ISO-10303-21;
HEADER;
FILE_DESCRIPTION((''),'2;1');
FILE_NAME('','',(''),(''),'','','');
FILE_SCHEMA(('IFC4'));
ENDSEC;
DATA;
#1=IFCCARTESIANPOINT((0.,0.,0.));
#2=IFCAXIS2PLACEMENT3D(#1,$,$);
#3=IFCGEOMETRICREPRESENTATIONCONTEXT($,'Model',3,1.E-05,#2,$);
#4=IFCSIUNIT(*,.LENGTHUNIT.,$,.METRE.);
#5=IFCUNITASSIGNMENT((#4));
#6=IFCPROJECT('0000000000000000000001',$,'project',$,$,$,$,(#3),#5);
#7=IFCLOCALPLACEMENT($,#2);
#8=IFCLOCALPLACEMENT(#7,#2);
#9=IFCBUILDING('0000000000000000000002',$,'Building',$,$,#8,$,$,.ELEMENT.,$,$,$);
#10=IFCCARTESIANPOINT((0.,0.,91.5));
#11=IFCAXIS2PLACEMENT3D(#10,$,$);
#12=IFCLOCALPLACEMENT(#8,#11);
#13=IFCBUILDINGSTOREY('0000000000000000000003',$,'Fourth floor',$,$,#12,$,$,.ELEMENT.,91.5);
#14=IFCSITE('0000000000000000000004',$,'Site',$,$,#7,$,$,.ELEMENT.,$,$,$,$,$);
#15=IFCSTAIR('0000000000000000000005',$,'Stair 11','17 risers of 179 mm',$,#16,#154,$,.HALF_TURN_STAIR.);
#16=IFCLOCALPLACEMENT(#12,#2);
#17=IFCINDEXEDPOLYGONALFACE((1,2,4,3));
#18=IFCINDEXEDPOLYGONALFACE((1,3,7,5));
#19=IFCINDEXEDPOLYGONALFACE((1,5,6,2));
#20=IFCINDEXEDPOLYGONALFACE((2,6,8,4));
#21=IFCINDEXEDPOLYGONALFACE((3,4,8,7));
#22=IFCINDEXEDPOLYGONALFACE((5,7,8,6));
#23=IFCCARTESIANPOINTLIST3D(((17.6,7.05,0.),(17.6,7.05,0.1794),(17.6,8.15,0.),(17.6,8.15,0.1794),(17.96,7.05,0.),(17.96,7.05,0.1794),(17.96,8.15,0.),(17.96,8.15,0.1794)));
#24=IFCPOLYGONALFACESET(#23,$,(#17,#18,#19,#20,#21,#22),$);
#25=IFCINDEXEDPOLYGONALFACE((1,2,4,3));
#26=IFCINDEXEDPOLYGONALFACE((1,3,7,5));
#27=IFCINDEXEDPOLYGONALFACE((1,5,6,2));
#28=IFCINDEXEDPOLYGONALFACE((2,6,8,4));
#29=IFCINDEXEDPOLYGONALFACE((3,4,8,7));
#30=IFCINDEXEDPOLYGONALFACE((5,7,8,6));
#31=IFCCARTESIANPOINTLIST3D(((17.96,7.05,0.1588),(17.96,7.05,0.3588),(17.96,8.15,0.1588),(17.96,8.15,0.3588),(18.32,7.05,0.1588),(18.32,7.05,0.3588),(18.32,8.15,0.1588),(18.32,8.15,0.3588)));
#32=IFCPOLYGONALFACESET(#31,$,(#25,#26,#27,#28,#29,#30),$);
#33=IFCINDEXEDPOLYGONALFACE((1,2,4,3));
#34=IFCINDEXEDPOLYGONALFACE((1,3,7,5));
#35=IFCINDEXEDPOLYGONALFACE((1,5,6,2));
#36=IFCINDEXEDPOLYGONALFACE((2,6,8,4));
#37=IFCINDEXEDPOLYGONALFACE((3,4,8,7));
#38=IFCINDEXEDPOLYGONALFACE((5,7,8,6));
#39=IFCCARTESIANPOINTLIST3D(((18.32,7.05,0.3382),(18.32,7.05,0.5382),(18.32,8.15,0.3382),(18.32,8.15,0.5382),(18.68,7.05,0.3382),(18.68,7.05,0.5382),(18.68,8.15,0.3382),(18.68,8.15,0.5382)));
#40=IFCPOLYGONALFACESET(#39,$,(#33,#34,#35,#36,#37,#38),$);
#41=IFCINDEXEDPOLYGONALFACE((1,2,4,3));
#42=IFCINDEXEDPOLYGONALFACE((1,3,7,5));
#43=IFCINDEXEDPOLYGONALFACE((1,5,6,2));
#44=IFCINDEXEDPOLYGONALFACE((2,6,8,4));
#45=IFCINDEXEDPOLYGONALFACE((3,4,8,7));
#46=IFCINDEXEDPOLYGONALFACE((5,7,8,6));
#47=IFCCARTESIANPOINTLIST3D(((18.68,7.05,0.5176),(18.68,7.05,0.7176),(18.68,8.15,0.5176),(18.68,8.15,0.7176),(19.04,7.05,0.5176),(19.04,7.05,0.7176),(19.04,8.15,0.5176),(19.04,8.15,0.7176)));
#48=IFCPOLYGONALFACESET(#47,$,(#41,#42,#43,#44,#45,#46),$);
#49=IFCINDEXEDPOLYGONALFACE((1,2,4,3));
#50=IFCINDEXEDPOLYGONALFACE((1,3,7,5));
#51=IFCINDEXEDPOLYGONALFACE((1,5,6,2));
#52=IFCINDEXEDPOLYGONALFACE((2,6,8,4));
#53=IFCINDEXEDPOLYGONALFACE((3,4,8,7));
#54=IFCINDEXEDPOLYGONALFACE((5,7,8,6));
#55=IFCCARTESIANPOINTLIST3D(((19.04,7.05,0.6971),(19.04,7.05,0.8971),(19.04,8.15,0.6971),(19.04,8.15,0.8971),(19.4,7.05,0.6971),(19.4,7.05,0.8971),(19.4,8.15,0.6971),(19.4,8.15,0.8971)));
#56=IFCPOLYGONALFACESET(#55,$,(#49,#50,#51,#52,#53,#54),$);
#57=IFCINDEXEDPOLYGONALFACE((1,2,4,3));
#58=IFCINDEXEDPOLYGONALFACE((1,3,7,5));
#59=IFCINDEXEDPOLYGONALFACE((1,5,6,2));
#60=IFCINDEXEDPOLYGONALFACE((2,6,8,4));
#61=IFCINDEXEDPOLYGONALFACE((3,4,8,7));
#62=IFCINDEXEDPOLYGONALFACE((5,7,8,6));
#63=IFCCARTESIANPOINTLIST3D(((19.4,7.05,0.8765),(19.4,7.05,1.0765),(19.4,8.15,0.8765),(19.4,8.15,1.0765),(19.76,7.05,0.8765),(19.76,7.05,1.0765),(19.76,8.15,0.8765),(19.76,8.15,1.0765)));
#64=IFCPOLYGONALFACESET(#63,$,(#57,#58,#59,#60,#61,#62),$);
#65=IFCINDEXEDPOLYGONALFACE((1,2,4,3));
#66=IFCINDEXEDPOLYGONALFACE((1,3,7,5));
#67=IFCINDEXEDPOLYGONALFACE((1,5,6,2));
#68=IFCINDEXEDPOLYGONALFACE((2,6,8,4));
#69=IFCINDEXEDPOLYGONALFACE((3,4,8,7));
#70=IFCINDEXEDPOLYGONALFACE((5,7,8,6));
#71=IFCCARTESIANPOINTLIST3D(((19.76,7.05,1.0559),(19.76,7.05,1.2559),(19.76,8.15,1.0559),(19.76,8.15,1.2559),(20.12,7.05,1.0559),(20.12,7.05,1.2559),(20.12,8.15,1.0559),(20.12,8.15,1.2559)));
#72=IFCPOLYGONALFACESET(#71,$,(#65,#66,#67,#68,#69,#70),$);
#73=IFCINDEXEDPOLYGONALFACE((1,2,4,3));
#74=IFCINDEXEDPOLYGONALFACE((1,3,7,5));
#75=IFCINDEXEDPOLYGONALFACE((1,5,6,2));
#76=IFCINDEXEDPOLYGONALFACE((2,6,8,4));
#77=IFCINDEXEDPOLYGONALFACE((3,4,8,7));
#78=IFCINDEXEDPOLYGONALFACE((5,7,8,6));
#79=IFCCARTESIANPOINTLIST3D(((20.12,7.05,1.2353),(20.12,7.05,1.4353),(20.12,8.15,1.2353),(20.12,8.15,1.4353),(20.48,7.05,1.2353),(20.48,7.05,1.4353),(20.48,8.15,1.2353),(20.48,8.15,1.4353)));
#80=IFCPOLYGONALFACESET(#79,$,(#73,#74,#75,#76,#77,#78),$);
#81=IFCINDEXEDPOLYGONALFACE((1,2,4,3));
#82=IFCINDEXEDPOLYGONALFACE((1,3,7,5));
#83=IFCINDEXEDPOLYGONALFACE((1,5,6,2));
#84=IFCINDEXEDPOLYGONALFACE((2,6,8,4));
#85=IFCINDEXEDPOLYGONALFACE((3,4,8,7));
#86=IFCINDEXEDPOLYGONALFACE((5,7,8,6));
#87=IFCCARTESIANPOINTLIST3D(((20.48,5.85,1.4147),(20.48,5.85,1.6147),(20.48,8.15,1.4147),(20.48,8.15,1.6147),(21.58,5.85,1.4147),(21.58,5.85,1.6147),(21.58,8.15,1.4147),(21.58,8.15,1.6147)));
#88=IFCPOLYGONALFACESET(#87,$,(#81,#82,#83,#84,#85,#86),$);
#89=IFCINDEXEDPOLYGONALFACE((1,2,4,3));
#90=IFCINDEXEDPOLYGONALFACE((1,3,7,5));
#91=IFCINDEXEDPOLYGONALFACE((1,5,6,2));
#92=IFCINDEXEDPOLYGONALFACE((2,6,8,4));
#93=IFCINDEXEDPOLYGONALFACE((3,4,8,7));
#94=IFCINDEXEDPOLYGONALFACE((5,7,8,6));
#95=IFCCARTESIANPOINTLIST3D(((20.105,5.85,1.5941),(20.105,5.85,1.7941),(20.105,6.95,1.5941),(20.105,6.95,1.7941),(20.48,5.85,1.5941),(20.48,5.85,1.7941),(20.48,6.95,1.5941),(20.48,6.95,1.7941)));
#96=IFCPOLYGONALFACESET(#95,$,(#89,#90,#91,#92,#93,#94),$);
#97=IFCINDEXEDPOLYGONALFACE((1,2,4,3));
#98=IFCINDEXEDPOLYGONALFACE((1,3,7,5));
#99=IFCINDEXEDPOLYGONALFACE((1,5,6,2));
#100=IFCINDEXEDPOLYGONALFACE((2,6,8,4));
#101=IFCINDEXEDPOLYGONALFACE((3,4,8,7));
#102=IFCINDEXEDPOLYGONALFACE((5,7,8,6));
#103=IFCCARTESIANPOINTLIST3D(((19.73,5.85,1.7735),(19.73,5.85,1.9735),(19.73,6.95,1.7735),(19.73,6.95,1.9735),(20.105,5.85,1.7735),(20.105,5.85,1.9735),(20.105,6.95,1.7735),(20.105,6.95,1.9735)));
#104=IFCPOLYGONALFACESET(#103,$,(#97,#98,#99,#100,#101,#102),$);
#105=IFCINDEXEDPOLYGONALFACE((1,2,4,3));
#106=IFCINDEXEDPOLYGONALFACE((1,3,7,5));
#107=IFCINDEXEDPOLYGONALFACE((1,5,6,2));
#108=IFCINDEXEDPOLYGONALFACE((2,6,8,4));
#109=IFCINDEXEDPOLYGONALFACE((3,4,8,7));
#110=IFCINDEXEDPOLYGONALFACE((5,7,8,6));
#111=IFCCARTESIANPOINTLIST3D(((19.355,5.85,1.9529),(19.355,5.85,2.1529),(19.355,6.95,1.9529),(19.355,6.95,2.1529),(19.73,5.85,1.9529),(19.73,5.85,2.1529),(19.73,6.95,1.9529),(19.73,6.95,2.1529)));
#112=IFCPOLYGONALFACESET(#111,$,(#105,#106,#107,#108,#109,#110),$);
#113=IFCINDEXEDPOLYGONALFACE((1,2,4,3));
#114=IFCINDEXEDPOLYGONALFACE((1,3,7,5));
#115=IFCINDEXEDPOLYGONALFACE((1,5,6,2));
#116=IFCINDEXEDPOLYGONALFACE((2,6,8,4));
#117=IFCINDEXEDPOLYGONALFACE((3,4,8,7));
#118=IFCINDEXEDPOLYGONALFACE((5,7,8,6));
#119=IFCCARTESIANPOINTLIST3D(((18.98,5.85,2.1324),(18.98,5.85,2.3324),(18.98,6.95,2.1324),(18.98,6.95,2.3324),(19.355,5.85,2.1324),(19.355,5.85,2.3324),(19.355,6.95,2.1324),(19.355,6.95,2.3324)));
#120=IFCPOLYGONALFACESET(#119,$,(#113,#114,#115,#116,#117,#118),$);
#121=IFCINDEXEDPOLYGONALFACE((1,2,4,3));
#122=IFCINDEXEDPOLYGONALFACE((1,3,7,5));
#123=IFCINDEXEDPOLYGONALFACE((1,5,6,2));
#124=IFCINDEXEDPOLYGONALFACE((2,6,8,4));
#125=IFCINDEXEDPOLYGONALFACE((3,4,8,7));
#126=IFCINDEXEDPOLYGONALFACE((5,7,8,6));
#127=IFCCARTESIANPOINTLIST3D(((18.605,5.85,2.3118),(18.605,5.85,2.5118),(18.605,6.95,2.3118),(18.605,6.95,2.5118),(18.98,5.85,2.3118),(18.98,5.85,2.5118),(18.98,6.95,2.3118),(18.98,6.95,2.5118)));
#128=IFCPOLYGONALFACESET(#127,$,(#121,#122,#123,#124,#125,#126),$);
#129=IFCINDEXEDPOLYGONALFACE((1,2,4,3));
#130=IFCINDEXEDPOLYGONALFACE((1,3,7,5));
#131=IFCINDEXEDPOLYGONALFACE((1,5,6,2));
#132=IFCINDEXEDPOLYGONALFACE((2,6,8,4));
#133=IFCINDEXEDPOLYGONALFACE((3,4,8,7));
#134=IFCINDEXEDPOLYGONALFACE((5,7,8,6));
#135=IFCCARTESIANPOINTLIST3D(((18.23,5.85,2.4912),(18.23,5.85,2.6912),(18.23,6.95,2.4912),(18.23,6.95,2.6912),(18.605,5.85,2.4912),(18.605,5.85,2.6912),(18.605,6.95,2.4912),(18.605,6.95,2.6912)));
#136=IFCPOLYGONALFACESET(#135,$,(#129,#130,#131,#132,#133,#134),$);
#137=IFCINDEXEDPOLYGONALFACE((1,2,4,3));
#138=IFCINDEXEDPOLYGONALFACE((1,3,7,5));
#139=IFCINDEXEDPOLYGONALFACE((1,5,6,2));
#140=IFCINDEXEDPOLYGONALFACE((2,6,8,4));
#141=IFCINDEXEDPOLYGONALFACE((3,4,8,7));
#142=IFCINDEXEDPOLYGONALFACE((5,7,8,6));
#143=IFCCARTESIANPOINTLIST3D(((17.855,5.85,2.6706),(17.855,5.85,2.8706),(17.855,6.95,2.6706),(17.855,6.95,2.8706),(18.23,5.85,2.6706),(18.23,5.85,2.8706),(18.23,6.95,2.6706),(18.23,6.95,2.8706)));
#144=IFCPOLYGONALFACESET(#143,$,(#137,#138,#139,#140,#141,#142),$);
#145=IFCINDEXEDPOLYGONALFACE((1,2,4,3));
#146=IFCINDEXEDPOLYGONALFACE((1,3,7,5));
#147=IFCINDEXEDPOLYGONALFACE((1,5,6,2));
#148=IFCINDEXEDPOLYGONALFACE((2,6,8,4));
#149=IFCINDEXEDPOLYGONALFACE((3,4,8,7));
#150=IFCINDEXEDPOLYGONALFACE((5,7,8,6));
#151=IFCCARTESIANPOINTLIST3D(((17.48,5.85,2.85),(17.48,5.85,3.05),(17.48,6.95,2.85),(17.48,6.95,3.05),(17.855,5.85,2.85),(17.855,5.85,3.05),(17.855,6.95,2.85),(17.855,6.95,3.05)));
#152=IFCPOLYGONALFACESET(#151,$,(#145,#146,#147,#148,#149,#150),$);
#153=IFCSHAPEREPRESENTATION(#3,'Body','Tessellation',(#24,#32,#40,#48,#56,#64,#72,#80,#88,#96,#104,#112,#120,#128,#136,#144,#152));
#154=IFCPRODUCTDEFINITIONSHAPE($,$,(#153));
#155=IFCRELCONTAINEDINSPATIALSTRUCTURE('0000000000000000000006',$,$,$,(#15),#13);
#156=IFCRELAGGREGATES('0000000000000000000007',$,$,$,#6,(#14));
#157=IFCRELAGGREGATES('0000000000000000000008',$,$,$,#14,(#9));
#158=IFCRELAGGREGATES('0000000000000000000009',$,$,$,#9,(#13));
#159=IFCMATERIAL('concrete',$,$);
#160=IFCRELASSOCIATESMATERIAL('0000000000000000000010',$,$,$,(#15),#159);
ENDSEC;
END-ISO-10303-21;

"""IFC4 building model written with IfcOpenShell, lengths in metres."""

from ifc_helpers import new_model, si_unit, frame, origin, place, context, project, spatial, polyline, outline, extrude, material, element, save


model = new_model("IFC4")

# Units and contexts
model_context = context("Model", 3, precision=1e-05, world=origin())
ifc_project = project(units=[si_unit("LENGTHUNIT", "METRE")], contexts=[model_context])

# Site, building, storey
site_placement = place(None, origin())
site = spatial("IfcSite", under=ifc_project, at=site_placement, Name="Site", CompositionType="ELEMENT")
building_placement = place(site_placement, origin())
building = spatial("IfcBuilding", under=site, at=building_placement, Name="Building", CompositionType="ELEMENT")
storey_placement = place(building_placement, frame((0.0, 0.0, 91.5)))
storey = spatial("IfcBuildingStorey", under=building, at=storey_placement, Name="Fourth floor", CompositionType="ELEMENT", Elevation=91.5)

# Shared definitions
ifc_material = material(Name="concrete")

# Stair
stair_1_placement = place(storey_placement, frame((17.6, 7.6, 0.0), z_axis=(0.0, 0.0, 1.0), x_axis=(1.0, 0.0, 0.0)))
element("IfcStair", 1, at=stair_1_placement, inside=storey, material=ifc_material, Name="Stair 11", Description="17 risers of 179 mm", PredefinedType="HALF_TURN_STAIR", context=model_context, shape_type="SweptSolid", body=[
    extrude(outline(polyline([(0.0, -0.55), (0.36, -0.55), (0.36, 0.55), (0.0, 0.55), (0.0, -0.55)])), origin(), (0.0, 0.0, 1.0), 0.1794),
    extrude(outline(polyline([(0.36, -0.55), (0.72, -0.55), (0.72, 0.55), (0.36, 0.55), (0.36, -0.55)])), frame((0.0, 0.0, 0.1588)), (0.0, 0.0, 1.0), 0.2),
    extrude(outline(polyline([(0.72, -0.55), (1.08, -0.55), (1.08, 0.55), (0.72, 0.55), (0.72, -0.55)])), frame((0.0, 0.0, 0.3382)), (0.0, 0.0, 1.0), 0.2),
    extrude(outline(polyline([(1.08, -0.55), (1.44, -0.55), (1.44, 0.55), (1.08, 0.55), (1.08, -0.55)])), frame((0.0, 0.0, 0.5176)), (0.0, 0.0, 1.0), 0.2),
    extrude(outline(polyline([(1.44, -0.55), (1.8, -0.55), (1.8, 0.55), (1.44, 0.55), (1.44, -0.55)])), frame((0.0, 0.0, 0.6971)), (0.0, 0.0, 1.0), 0.2),
    extrude(outline(polyline([(1.8, -0.55), (2.16, -0.55), (2.16, 0.55), (1.8, 0.55), (1.8, -0.55)])), frame((0.0, 0.0, 0.8765)), (0.0, 0.0, 1.0), 0.2),
    extrude(outline(polyline([(2.16, -0.55), (2.52, -0.55), (2.52, 0.55), (2.16, 0.55), (2.16, -0.55)])), frame((0.0, 0.0, 1.0559)), (0.0, 0.0, 1.0), 0.2),
    extrude(outline(polyline([(2.52, -0.55), (2.88, -0.55), (2.88, 0.55), (2.52, 0.55), (2.52, -0.55)])), frame((0.0, 0.0, 1.2353)), (0.0, 0.0, 1.0), 0.2),
    extrude(outline(polyline([(2.88, -1.75), (3.98, -1.75), (3.98, 0.55), (2.88, 0.55), (2.88, -1.75)])), frame((0.0, 0.0, 1.4147)), (0.0, 0.0, 1.0), 0.2),
    extrude(outline(polyline([(2.505, -1.75), (2.88, -1.75), (2.88, -0.65), (2.505, -0.65), (2.505, -1.75)])), frame((0.0, 0.0, 1.5941)), (0.0, 0.0, 1.0), 0.2),
    extrude(outline(polyline([(2.13, -1.75), (2.505, -1.75), (2.505, -0.65), (2.13, -0.65), (2.13, -1.75)])), frame((0.0, 0.0, 1.7735)), (0.0, 0.0, 1.0), 0.2),
    extrude(outline(polyline([(1.755, -1.75), (2.13, -1.75), (2.13, -0.65), (1.755, -0.65), (1.755, -1.75)])), frame((0.0, 0.0, 1.9529)), (0.0, 0.0, 1.0), 0.2),
    extrude(outline(polyline([(1.38, -1.75), (1.755, -1.75), (1.755, -0.65), (1.38, -0.65), (1.38, -1.75)])), frame((0.0, 0.0, 2.1324)), (0.0, 0.0, 1.0), 0.2),
    extrude(outline(polyline([(1.005, -1.75), (1.38, -1.75), (1.38, -0.65), (1.005, -0.65), (1.005, -1.75)])), frame((0.0, 0.0, 2.3118)), (0.0, 0.0, 1.0), 0.2),
    extrude(outline(polyline([(0.63, -1.75), (1.005, -1.75), (1.005, -0.65), (0.63, -0.65), (0.63, -1.75)])), frame((0.0, 0.0, 2.4912)), (0.0, 0.0, 1.0), 0.2),
    extrude(outline(polyline([(0.255, -1.75), (0.63, -1.75), (0.63, -0.65), (0.255, -0.65), (0.255, -1.75)])), frame((0.0, 0.0, 2.6706)), (0.0, 0.0, 1.0), 0.2),
    extrude(outline(polyline([(-0.12, -1.75), (0.255, -1.75), (0.255, -0.65), (-0.12, -0.65), (-0.12, -1.75)])), frame((0.0, 0.0, 2.85)), (0.0, 0.0, 1.0), 0.2),
])

save(model, "model.ifc")
